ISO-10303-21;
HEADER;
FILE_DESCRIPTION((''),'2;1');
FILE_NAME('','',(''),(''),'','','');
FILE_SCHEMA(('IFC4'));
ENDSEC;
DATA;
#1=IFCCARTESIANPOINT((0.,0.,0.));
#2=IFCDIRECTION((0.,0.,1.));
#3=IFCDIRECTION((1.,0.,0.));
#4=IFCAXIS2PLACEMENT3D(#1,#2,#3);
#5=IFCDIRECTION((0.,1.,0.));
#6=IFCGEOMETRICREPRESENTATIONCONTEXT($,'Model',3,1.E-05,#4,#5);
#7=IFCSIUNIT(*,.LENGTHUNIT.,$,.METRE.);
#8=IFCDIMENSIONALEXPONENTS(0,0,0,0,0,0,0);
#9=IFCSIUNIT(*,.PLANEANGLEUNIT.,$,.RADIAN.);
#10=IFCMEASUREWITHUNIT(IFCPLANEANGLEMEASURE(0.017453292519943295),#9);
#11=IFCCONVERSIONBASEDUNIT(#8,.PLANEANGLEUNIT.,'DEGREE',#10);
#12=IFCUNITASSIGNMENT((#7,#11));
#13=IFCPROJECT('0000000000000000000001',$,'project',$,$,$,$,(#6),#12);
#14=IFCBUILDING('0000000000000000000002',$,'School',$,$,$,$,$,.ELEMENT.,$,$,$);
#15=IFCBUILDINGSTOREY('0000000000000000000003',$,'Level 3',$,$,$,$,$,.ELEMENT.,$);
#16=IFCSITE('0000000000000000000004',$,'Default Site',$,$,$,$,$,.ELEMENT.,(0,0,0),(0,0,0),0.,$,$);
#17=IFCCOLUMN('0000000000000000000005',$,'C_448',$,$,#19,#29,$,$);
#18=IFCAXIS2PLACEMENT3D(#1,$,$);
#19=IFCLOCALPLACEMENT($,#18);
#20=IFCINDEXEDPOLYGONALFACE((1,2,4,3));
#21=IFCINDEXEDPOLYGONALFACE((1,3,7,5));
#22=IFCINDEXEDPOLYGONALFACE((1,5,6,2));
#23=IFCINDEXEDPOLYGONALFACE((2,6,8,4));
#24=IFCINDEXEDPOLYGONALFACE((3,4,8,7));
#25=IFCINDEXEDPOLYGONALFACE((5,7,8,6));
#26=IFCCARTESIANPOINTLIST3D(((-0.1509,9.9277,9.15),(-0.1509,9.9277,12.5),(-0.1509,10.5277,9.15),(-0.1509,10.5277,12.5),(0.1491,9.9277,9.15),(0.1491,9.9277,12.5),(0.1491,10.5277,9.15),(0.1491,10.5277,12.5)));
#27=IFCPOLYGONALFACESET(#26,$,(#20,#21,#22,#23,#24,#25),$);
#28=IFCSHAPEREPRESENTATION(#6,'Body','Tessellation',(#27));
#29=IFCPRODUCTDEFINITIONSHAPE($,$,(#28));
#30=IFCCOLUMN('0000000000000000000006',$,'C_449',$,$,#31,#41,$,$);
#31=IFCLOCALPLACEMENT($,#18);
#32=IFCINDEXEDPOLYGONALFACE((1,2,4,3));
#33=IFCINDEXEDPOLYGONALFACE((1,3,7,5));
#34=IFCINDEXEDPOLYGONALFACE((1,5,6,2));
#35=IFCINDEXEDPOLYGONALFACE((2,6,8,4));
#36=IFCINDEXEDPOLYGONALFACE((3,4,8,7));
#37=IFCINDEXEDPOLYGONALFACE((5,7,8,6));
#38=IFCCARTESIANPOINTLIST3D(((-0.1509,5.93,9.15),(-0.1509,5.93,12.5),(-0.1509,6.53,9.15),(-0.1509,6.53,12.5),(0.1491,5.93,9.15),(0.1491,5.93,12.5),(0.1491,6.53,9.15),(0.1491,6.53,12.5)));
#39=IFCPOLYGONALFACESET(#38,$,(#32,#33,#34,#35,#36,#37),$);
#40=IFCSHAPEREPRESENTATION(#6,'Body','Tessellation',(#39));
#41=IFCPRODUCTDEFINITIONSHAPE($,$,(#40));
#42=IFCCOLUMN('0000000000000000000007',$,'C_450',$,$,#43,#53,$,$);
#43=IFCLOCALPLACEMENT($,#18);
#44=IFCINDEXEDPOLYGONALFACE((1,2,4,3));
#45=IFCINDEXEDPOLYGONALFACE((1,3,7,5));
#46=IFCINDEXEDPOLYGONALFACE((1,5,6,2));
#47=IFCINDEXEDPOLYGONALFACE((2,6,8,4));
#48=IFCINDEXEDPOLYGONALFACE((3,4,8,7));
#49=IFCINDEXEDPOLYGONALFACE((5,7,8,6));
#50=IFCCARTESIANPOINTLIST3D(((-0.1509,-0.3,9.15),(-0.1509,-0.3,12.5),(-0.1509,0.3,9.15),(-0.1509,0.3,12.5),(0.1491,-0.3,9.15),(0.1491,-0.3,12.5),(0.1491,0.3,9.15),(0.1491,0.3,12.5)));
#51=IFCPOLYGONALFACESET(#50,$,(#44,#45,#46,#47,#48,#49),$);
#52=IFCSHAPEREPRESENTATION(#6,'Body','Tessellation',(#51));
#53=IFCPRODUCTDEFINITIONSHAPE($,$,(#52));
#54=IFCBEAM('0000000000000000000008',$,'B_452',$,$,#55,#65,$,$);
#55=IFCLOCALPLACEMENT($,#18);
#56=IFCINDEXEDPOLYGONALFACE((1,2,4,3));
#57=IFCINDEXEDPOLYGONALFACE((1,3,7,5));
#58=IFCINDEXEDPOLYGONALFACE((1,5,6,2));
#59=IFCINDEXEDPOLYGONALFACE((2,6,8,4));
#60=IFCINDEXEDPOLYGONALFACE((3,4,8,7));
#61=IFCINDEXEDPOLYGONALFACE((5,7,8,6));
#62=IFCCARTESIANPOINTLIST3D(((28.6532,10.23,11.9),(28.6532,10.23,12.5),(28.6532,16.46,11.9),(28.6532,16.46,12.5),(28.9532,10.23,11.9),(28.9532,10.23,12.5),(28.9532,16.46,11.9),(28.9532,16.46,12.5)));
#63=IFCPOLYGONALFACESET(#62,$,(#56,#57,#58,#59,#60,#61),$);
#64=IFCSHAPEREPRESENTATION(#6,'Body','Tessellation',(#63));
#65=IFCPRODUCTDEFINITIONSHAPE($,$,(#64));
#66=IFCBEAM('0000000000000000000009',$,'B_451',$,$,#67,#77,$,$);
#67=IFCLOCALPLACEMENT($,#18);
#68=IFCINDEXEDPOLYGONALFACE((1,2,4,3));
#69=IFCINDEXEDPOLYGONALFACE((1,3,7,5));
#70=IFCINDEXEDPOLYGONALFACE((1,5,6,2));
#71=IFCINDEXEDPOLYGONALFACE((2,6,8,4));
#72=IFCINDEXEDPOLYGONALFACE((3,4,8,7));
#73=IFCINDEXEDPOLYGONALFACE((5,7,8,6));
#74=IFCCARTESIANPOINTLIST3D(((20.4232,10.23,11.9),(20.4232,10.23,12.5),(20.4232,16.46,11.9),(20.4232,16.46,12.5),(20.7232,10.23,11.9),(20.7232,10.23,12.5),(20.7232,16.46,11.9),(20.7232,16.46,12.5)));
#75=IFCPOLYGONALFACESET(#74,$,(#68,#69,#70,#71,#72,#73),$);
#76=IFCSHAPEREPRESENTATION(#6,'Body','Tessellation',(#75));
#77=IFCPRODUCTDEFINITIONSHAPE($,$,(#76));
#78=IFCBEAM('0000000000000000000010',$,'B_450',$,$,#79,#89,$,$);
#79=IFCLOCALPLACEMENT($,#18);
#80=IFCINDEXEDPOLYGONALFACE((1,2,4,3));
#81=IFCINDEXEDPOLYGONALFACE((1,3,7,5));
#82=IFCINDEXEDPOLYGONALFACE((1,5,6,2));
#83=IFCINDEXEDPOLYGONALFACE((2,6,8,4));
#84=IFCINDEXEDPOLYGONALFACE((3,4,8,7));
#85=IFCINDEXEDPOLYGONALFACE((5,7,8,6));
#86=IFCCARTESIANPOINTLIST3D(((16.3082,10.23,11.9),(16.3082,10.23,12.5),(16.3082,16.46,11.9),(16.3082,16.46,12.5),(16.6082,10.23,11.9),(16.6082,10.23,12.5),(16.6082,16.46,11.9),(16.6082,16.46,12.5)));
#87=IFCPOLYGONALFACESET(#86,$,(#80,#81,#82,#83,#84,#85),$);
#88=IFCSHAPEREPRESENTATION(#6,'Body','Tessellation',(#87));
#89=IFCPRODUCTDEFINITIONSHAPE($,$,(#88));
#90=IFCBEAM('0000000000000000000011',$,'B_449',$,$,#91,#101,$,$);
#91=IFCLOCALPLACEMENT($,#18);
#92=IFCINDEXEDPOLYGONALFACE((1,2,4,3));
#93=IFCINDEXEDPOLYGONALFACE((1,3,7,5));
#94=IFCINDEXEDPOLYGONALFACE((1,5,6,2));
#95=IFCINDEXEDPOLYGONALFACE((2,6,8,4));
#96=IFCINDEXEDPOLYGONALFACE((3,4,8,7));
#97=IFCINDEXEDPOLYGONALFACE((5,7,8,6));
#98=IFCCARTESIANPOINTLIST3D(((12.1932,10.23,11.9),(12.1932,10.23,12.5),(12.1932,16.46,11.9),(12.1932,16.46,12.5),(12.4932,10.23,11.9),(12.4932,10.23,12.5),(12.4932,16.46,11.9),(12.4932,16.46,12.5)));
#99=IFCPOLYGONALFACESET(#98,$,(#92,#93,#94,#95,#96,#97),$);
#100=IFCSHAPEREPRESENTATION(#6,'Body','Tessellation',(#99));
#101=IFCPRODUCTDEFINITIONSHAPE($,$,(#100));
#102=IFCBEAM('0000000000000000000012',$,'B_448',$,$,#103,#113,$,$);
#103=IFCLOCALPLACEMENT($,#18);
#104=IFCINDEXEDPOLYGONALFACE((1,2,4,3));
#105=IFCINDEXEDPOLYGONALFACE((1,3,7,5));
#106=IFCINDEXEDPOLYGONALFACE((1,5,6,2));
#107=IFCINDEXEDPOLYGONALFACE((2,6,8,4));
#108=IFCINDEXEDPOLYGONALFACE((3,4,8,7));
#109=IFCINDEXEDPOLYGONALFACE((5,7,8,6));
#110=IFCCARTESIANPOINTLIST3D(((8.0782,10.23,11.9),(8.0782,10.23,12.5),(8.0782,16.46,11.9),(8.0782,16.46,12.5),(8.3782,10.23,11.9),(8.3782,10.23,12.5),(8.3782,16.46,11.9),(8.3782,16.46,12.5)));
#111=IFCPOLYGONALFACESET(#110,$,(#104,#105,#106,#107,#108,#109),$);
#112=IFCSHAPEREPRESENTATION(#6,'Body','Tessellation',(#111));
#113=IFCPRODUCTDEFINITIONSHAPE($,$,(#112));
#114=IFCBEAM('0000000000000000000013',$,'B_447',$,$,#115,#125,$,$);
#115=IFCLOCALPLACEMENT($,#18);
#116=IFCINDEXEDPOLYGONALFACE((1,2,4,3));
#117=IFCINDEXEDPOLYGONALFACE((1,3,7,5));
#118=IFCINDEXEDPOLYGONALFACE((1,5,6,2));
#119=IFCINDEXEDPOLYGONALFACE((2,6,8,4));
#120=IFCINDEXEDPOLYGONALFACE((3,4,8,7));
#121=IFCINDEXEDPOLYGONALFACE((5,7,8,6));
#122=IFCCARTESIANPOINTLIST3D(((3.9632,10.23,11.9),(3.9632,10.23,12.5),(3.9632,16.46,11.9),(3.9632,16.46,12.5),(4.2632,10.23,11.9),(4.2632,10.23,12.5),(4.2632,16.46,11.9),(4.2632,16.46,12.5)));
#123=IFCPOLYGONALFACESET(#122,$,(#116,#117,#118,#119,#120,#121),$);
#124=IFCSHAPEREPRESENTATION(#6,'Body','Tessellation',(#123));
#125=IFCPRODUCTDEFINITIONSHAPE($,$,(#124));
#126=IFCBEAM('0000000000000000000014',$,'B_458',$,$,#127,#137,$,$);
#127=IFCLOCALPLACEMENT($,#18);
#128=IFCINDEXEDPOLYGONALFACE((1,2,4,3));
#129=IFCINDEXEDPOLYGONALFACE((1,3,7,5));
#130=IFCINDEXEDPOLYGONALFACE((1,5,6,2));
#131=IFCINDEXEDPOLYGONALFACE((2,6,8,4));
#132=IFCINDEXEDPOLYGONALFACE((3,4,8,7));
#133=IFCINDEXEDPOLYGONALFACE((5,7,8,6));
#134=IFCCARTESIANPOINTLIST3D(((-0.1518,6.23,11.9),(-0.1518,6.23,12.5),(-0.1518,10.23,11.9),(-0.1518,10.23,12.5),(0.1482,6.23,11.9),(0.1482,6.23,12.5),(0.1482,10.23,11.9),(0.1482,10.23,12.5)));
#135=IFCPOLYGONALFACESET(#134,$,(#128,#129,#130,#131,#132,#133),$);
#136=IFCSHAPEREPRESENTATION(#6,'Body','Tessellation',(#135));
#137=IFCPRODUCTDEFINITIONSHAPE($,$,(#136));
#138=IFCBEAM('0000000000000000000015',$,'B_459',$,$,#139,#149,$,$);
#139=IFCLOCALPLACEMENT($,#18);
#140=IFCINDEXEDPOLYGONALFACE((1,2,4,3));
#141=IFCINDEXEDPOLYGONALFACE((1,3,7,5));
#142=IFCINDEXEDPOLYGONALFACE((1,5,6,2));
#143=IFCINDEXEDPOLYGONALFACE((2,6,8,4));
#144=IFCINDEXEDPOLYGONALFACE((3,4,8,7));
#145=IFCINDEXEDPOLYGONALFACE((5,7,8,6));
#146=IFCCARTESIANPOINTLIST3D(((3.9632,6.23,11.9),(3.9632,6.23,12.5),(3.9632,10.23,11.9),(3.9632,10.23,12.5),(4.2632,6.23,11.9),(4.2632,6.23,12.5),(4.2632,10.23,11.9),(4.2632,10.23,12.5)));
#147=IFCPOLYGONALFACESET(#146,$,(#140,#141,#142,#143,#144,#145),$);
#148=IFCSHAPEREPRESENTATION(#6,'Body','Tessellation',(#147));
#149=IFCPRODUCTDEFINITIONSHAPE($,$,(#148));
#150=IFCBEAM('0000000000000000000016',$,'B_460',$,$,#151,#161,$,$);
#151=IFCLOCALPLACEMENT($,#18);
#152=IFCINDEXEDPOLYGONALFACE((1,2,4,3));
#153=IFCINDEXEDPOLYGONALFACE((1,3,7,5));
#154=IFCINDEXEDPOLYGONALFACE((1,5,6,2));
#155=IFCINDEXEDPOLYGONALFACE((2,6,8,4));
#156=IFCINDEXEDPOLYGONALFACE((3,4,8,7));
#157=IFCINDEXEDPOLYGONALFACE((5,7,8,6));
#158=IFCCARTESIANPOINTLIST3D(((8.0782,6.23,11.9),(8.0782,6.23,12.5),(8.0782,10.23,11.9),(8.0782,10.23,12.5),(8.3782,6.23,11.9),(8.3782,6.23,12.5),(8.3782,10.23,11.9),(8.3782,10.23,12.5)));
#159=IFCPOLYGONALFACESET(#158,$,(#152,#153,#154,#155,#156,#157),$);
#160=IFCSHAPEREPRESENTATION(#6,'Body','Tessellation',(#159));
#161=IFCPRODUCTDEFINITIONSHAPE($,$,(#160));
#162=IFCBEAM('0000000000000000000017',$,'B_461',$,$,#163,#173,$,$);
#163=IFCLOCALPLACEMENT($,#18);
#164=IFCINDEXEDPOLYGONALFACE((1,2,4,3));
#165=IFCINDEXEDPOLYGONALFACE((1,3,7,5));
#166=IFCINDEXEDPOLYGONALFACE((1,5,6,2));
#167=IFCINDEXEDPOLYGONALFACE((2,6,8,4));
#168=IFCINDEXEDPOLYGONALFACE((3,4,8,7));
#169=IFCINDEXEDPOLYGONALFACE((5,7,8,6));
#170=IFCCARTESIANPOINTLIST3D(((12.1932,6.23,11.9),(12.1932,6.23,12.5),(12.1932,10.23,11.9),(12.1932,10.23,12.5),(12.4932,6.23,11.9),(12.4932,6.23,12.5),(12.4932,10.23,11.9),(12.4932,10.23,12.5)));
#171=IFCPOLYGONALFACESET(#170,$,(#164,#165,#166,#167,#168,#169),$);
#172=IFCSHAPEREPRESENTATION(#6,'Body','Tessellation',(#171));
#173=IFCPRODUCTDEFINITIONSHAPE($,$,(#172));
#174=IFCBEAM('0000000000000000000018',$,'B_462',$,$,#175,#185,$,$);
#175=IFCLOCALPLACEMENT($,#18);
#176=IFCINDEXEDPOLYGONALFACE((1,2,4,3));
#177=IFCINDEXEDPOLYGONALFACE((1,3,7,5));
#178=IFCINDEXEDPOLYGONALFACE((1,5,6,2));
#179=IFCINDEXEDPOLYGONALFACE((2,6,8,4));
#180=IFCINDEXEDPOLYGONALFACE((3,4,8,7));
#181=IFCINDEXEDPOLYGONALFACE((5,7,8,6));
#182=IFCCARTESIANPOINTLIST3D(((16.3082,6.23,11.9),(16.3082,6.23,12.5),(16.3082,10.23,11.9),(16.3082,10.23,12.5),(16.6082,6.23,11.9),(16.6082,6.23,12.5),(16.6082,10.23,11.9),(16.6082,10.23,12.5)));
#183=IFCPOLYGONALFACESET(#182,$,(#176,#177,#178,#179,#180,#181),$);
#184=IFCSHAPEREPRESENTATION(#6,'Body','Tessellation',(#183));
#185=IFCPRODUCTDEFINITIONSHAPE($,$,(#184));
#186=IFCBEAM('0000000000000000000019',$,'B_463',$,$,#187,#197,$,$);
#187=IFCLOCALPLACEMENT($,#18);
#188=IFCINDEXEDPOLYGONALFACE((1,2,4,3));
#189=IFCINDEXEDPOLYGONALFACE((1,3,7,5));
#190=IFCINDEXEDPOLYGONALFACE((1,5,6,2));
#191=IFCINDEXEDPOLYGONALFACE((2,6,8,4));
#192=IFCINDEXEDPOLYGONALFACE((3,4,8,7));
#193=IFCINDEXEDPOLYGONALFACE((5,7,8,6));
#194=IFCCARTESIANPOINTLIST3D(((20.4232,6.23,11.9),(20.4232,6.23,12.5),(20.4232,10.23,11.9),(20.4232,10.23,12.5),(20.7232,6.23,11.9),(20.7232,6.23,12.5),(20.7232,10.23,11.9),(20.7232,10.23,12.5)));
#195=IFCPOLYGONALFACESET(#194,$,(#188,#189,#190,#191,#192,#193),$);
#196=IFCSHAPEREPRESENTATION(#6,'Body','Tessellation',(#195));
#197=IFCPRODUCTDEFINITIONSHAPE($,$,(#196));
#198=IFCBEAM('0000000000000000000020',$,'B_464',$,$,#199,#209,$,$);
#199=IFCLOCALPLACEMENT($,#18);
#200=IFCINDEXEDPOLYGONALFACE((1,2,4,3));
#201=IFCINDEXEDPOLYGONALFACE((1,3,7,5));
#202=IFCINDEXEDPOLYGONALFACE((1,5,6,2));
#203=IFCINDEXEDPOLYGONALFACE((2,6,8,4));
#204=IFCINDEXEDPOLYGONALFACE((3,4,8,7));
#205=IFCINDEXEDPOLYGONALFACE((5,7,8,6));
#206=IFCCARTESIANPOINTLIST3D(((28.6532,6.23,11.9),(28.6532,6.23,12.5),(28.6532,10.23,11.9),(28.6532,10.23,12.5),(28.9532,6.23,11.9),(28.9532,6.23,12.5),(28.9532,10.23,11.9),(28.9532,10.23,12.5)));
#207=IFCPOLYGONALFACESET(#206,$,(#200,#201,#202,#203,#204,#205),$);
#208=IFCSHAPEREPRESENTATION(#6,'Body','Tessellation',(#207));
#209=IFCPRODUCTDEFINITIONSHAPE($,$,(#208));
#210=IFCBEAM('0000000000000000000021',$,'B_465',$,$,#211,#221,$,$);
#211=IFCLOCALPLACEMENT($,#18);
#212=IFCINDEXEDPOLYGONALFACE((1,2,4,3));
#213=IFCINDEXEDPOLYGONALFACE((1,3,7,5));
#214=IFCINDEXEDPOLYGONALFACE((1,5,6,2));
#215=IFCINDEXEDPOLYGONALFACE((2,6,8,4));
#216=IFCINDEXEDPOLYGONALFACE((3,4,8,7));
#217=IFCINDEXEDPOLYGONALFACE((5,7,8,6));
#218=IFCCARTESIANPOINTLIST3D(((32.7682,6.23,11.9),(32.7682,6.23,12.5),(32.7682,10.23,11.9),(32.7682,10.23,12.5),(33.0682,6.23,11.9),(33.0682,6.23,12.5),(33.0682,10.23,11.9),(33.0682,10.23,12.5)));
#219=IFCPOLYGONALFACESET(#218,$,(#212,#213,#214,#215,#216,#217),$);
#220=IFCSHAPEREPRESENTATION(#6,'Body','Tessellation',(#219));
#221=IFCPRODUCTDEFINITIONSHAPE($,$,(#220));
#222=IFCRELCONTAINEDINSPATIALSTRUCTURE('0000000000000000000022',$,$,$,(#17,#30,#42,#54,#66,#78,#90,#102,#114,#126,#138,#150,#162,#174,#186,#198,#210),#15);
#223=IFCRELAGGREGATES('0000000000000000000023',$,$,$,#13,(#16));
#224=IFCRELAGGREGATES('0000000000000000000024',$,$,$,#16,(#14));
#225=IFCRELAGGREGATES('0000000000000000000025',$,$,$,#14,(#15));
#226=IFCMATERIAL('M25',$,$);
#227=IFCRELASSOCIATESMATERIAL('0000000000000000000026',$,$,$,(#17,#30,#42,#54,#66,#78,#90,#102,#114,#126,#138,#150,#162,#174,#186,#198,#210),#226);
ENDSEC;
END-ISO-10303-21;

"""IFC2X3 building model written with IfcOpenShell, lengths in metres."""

from ifc_helpers import new_model, entity, si_unit, converted_unit, direction, frame, frame_2d, origin_with_axes, place, context, project, spatial, rectangle, extrude, material, element, save


model = new_model("IFC2X3")

# Units and contexts
model_context = context("Model", 3, precision=1e-05, world=origin_with_axes(), true_north=direction((0.0, 1.0, 0.0)))
ifc_project = project(units=[si_unit("LENGTHUNIT", "METRE"), converted_unit("PLANEANGLEUNIT", "DEGREE", entity("IfcPlaneAngleMeasure", 0.017453292519943295), si_unit("PLANEANGLEUNIT", "RADIAN"), dimensions=[0, 0, 0, 0, 0, 0, 0])], contexts=[model_context])

# Site, building, storey
site = spatial("IfcSite", under=ifc_project, Name="Default Site", CompositionType="ELEMENT", RefLatitude=(0, 0, 0), RefLongitude=(0, 0, 0), RefElevation=0.0)
building = spatial("IfcBuilding", under=site, Name="School", CompositionType="ELEMENT")
storey = spatial("IfcBuildingStorey", under=building, Name="Level 3", CompositionType="ELEMENT")

# Columns
ifc_material = material(Name="M25")
placement = place(None, origin_with_axes())
element("IfcColumn", 1, at=placement, inside=storey, material=ifc_material, Name="C_448", context=model_context, shape_type="SweptSolid", body=[
    extrude(rectangle(XDim=0.3, YDim=0.6, at=frame_2d((0.0, 0.0), x_axis=(1.0, 0.0, 0.0))), frame((-0.0009, 10.2277, 9.15), z_axis=(0.0, 0.0, 1.0), x_axis=(1.0, 0.0, 0.0)), (0.0, 0.0, 1.0), 3.35),
])
element("IfcColumn", 2, at=placement, inside=storey, material=ifc_material, Name="C_449", context=model_context, shape_type="SweptSolid", body=[
    extrude(rectangle(XDim=0.3, YDim=0.6, at=frame_2d((0.0, 0.0), x_axis=(1.0, 0.0, 0.0))), frame((-0.0009, 6.23, 9.15), z_axis=(0.0, 0.0, 1.0), x_axis=(1.0, 0.0, 0.0)), (0.0, 0.0, 1.0), 3.35),
])
element("IfcColumn", 3, at=placement, inside=storey, material=ifc_material, Name="C_450", context=model_context, shape_type="SweptSolid", body=[
    extrude(rectangle(XDim=0.3, YDim=0.6, at=frame_2d((0.0, 0.0), x_axis=(1.0, 0.0, 0.0))), frame((-0.0009, 0.0, 9.15), z_axis=(0.0, 0.0, 1.0), x_axis=(1.0, 0.0, 0.0)), (0.0, 0.0, 1.0), 3.35),
])

# Beams
element("IfcBeam", 4, at=placement, inside=storey, material=ifc_material, Name="B_452", context=model_context, shape_type="SweptSolid", body=[
    extrude(rectangle(XDim=0.3, YDim=0.6, at=frame_2d((0.0, 0.0), x_axis=(0.0, 1.0, 0.0))), frame((28.8032, 10.23, 12.2), z_axis=(0.0, 1.0, 0.0), x_axis=(0.0, 0.0, -1.0)), (0.0, 0.0, 1.0), 6.23),
])
element("IfcBeam", 5, at=placement, inside=storey, material=ifc_material, Name="B_451", context=model_context, shape_type="SweptSolid", body=[
    extrude(rectangle(XDim=0.3, YDim=0.6, at=frame_2d((0.0, 0.0), x_axis=(0.0, 1.0, 0.0))), frame((20.5732, 10.23, 12.2), z_axis=(0.0, 1.0, 0.0), x_axis=(0.0, 0.0, -1.0)), (0.0, 0.0, 1.0), 6.23),
])
element("IfcBeam", 6, at=placement, inside=storey, material=ifc_material, Name="B_450", context=model_context, shape_type="SweptSolid", body=[
    extrude(rectangle(XDim=0.3, YDim=0.6, at=frame_2d((0.0, 0.0), x_axis=(0.0, 1.0, 0.0))), frame((16.4582, 10.23, 12.2), z_axis=(0.0, 1.0, 0.0), x_axis=(0.0, 0.0, -1.0)), (0.0, 0.0, 1.0), 6.23),
])
element("IfcBeam", 7, at=placement, inside=storey, material=ifc_material, Name="B_449", context=model_context, shape_type="SweptSolid", body=[
    extrude(rectangle(XDim=0.3, YDim=0.6, at=frame_2d((0.0, 0.0), x_axis=(0.0, 1.0, 0.0))), frame((12.3432, 10.23, 12.2), z_axis=(0.0, 1.0, 0.0), x_axis=(0.0, 0.0, -1.0)), (0.0, 0.0, 1.0), 6.23),
])
element("IfcBeam", 8, at=placement, inside=storey, material=ifc_material, Name="B_448", context=model_context, shape_type="SweptSolid", body=[
    extrude(rectangle(XDim=0.3, YDim=0.6, at=frame_2d((0.0, 0.0), x_axis=(0.0, 1.0, 0.0))), frame((8.2282, 10.23, 12.2), z_axis=(0.0, 1.0, 0.0), x_axis=(0.0, 0.0, -1.0)), (0.0, 0.0, 1.0), 6.23),
])
element("IfcBeam", 9, at=placement, inside=storey, material=ifc_material, Name="B_447", context=model_context, shape_type="SweptSolid", body=[
    extrude(rectangle(XDim=0.3, YDim=0.6, at=frame_2d((0.0, 0.0), x_axis=(0.0, 1.0, 0.0))), frame((4.1132, 10.23, 12.2), z_axis=(0.0, 1.0, 0.0), x_axis=(0.0, 0.0, -1.0)), (0.0, 0.0, 1.0), 6.23),
])
element("IfcBeam", 10, at=placement, inside=storey, material=ifc_material, Name="B_458", context=model_context, shape_type="SweptSolid", body=[
    extrude(rectangle(XDim=0.3, YDim=0.6, at=frame_2d((0.0, 0.0), x_axis=(0.0, 1.0, 0.0))), frame((-0.0018, 6.23, 12.2), z_axis=(0.0, 1.0, 0.0), x_axis=(0.0, 0.0, -1.0)), (0.0, 0.0, 1.0), 4.0),
])
element("IfcBeam", 11, at=placement, inside=storey, material=ifc_material, Name="B_459", context=model_context, shape_type="SweptSolid", body=[
    extrude(rectangle(XDim=0.3, YDim=0.6, at=frame_2d((0.0, 0.0), x_axis=(0.0, 1.0, 0.0))), frame((4.1132, 6.23, 12.2), z_axis=(0.0, 1.0, 0.0), x_axis=(0.0, 0.0, -1.0)), (0.0, 0.0, 1.0), 4.0),
])
element("IfcBeam", 12, at=placement, inside=storey, material=ifc_material, Name="B_460", context=model_context, shape_type="SweptSolid", body=[
    extrude(rectangle(XDim=0.3, YDim=0.6, at=frame_2d((0.0, 0.0), x_axis=(0.0, 1.0, 0.0))), frame((8.2282, 6.23, 12.2), z_axis=(0.0, 1.0, 0.0), x_axis=(0.0, 0.0, -1.0)), (0.0, 0.0, 1.0), 4.0),
])
element("IfcBeam", 13, at=placement, inside=storey, material=ifc_material, Name="B_461", context=model_context, shape_type="SweptSolid", body=[
    extrude(rectangle(XDim=0.3, YDim=0.6, at=frame_2d((0.0, 0.0), x_axis=(0.0, 1.0, 0.0))), frame((12.3432, 6.23, 12.2), z_axis=(0.0, 1.0, 0.0), x_axis=(0.0, 0.0, -1.0)), (0.0, 0.0, 1.0), 4.0),
])
element("IfcBeam", 14, at=placement, inside=storey, material=ifc_material, Name="B_462", context=model_context, shape_type="SweptSolid", body=[
    extrude(rectangle(XDim=0.3, YDim=0.6, at=frame_2d((0.0, 0.0), x_axis=(0.0, 1.0, 0.0))), frame((16.4582, 6.23, 12.2), z_axis=(0.0, 1.0, 0.0), x_axis=(0.0, 0.0, -1.0)), (0.0, 0.0, 1.0), 4.0),
])
element("IfcBeam", 15, at=placement, inside=storey, material=ifc_material, Name="B_463", context=model_context, shape_type="SweptSolid", body=[
    extrude(rectangle(XDim=0.3, YDim=0.6, at=frame_2d((0.0, 0.0), x_axis=(0.0, 1.0, 0.0))), frame((20.5732, 6.23, 12.2), z_axis=(0.0, 1.0, 0.0), x_axis=(0.0, 0.0, -1.0)), (0.0, 0.0, 1.0), 4.0),
])
element("IfcBeam", 16, at=placement, inside=storey, material=ifc_material, Name="B_464", context=model_context, shape_type="SweptSolid", body=[
    extrude(rectangle(XDim=0.3, YDim=0.6, at=frame_2d((0.0, 0.0), x_axis=(0.0, 1.0, 0.0))), frame((28.8032, 6.23, 12.2), z_axis=(0.0, 1.0, 0.0), x_axis=(0.0, 0.0, -1.0)), (0.0, 0.0, 1.0), 4.0),
])
element("IfcBeam", 17, at=placement, inside=storey, material=ifc_material, Name="B_465", context=model_context, shape_type="SweptSolid", body=[
    extrude(rectangle(XDim=0.3, YDim=0.6, at=frame_2d((0.0, 0.0), x_axis=(0.0, 1.0, 0.0))), frame((32.9182, 6.23, 12.2), z_axis=(0.0, 1.0, 0.0), x_axis=(0.0, 0.0, -1.0)), (0.0, 0.0, 1.0), 4.0),
])

save(model, "model.ifc")
